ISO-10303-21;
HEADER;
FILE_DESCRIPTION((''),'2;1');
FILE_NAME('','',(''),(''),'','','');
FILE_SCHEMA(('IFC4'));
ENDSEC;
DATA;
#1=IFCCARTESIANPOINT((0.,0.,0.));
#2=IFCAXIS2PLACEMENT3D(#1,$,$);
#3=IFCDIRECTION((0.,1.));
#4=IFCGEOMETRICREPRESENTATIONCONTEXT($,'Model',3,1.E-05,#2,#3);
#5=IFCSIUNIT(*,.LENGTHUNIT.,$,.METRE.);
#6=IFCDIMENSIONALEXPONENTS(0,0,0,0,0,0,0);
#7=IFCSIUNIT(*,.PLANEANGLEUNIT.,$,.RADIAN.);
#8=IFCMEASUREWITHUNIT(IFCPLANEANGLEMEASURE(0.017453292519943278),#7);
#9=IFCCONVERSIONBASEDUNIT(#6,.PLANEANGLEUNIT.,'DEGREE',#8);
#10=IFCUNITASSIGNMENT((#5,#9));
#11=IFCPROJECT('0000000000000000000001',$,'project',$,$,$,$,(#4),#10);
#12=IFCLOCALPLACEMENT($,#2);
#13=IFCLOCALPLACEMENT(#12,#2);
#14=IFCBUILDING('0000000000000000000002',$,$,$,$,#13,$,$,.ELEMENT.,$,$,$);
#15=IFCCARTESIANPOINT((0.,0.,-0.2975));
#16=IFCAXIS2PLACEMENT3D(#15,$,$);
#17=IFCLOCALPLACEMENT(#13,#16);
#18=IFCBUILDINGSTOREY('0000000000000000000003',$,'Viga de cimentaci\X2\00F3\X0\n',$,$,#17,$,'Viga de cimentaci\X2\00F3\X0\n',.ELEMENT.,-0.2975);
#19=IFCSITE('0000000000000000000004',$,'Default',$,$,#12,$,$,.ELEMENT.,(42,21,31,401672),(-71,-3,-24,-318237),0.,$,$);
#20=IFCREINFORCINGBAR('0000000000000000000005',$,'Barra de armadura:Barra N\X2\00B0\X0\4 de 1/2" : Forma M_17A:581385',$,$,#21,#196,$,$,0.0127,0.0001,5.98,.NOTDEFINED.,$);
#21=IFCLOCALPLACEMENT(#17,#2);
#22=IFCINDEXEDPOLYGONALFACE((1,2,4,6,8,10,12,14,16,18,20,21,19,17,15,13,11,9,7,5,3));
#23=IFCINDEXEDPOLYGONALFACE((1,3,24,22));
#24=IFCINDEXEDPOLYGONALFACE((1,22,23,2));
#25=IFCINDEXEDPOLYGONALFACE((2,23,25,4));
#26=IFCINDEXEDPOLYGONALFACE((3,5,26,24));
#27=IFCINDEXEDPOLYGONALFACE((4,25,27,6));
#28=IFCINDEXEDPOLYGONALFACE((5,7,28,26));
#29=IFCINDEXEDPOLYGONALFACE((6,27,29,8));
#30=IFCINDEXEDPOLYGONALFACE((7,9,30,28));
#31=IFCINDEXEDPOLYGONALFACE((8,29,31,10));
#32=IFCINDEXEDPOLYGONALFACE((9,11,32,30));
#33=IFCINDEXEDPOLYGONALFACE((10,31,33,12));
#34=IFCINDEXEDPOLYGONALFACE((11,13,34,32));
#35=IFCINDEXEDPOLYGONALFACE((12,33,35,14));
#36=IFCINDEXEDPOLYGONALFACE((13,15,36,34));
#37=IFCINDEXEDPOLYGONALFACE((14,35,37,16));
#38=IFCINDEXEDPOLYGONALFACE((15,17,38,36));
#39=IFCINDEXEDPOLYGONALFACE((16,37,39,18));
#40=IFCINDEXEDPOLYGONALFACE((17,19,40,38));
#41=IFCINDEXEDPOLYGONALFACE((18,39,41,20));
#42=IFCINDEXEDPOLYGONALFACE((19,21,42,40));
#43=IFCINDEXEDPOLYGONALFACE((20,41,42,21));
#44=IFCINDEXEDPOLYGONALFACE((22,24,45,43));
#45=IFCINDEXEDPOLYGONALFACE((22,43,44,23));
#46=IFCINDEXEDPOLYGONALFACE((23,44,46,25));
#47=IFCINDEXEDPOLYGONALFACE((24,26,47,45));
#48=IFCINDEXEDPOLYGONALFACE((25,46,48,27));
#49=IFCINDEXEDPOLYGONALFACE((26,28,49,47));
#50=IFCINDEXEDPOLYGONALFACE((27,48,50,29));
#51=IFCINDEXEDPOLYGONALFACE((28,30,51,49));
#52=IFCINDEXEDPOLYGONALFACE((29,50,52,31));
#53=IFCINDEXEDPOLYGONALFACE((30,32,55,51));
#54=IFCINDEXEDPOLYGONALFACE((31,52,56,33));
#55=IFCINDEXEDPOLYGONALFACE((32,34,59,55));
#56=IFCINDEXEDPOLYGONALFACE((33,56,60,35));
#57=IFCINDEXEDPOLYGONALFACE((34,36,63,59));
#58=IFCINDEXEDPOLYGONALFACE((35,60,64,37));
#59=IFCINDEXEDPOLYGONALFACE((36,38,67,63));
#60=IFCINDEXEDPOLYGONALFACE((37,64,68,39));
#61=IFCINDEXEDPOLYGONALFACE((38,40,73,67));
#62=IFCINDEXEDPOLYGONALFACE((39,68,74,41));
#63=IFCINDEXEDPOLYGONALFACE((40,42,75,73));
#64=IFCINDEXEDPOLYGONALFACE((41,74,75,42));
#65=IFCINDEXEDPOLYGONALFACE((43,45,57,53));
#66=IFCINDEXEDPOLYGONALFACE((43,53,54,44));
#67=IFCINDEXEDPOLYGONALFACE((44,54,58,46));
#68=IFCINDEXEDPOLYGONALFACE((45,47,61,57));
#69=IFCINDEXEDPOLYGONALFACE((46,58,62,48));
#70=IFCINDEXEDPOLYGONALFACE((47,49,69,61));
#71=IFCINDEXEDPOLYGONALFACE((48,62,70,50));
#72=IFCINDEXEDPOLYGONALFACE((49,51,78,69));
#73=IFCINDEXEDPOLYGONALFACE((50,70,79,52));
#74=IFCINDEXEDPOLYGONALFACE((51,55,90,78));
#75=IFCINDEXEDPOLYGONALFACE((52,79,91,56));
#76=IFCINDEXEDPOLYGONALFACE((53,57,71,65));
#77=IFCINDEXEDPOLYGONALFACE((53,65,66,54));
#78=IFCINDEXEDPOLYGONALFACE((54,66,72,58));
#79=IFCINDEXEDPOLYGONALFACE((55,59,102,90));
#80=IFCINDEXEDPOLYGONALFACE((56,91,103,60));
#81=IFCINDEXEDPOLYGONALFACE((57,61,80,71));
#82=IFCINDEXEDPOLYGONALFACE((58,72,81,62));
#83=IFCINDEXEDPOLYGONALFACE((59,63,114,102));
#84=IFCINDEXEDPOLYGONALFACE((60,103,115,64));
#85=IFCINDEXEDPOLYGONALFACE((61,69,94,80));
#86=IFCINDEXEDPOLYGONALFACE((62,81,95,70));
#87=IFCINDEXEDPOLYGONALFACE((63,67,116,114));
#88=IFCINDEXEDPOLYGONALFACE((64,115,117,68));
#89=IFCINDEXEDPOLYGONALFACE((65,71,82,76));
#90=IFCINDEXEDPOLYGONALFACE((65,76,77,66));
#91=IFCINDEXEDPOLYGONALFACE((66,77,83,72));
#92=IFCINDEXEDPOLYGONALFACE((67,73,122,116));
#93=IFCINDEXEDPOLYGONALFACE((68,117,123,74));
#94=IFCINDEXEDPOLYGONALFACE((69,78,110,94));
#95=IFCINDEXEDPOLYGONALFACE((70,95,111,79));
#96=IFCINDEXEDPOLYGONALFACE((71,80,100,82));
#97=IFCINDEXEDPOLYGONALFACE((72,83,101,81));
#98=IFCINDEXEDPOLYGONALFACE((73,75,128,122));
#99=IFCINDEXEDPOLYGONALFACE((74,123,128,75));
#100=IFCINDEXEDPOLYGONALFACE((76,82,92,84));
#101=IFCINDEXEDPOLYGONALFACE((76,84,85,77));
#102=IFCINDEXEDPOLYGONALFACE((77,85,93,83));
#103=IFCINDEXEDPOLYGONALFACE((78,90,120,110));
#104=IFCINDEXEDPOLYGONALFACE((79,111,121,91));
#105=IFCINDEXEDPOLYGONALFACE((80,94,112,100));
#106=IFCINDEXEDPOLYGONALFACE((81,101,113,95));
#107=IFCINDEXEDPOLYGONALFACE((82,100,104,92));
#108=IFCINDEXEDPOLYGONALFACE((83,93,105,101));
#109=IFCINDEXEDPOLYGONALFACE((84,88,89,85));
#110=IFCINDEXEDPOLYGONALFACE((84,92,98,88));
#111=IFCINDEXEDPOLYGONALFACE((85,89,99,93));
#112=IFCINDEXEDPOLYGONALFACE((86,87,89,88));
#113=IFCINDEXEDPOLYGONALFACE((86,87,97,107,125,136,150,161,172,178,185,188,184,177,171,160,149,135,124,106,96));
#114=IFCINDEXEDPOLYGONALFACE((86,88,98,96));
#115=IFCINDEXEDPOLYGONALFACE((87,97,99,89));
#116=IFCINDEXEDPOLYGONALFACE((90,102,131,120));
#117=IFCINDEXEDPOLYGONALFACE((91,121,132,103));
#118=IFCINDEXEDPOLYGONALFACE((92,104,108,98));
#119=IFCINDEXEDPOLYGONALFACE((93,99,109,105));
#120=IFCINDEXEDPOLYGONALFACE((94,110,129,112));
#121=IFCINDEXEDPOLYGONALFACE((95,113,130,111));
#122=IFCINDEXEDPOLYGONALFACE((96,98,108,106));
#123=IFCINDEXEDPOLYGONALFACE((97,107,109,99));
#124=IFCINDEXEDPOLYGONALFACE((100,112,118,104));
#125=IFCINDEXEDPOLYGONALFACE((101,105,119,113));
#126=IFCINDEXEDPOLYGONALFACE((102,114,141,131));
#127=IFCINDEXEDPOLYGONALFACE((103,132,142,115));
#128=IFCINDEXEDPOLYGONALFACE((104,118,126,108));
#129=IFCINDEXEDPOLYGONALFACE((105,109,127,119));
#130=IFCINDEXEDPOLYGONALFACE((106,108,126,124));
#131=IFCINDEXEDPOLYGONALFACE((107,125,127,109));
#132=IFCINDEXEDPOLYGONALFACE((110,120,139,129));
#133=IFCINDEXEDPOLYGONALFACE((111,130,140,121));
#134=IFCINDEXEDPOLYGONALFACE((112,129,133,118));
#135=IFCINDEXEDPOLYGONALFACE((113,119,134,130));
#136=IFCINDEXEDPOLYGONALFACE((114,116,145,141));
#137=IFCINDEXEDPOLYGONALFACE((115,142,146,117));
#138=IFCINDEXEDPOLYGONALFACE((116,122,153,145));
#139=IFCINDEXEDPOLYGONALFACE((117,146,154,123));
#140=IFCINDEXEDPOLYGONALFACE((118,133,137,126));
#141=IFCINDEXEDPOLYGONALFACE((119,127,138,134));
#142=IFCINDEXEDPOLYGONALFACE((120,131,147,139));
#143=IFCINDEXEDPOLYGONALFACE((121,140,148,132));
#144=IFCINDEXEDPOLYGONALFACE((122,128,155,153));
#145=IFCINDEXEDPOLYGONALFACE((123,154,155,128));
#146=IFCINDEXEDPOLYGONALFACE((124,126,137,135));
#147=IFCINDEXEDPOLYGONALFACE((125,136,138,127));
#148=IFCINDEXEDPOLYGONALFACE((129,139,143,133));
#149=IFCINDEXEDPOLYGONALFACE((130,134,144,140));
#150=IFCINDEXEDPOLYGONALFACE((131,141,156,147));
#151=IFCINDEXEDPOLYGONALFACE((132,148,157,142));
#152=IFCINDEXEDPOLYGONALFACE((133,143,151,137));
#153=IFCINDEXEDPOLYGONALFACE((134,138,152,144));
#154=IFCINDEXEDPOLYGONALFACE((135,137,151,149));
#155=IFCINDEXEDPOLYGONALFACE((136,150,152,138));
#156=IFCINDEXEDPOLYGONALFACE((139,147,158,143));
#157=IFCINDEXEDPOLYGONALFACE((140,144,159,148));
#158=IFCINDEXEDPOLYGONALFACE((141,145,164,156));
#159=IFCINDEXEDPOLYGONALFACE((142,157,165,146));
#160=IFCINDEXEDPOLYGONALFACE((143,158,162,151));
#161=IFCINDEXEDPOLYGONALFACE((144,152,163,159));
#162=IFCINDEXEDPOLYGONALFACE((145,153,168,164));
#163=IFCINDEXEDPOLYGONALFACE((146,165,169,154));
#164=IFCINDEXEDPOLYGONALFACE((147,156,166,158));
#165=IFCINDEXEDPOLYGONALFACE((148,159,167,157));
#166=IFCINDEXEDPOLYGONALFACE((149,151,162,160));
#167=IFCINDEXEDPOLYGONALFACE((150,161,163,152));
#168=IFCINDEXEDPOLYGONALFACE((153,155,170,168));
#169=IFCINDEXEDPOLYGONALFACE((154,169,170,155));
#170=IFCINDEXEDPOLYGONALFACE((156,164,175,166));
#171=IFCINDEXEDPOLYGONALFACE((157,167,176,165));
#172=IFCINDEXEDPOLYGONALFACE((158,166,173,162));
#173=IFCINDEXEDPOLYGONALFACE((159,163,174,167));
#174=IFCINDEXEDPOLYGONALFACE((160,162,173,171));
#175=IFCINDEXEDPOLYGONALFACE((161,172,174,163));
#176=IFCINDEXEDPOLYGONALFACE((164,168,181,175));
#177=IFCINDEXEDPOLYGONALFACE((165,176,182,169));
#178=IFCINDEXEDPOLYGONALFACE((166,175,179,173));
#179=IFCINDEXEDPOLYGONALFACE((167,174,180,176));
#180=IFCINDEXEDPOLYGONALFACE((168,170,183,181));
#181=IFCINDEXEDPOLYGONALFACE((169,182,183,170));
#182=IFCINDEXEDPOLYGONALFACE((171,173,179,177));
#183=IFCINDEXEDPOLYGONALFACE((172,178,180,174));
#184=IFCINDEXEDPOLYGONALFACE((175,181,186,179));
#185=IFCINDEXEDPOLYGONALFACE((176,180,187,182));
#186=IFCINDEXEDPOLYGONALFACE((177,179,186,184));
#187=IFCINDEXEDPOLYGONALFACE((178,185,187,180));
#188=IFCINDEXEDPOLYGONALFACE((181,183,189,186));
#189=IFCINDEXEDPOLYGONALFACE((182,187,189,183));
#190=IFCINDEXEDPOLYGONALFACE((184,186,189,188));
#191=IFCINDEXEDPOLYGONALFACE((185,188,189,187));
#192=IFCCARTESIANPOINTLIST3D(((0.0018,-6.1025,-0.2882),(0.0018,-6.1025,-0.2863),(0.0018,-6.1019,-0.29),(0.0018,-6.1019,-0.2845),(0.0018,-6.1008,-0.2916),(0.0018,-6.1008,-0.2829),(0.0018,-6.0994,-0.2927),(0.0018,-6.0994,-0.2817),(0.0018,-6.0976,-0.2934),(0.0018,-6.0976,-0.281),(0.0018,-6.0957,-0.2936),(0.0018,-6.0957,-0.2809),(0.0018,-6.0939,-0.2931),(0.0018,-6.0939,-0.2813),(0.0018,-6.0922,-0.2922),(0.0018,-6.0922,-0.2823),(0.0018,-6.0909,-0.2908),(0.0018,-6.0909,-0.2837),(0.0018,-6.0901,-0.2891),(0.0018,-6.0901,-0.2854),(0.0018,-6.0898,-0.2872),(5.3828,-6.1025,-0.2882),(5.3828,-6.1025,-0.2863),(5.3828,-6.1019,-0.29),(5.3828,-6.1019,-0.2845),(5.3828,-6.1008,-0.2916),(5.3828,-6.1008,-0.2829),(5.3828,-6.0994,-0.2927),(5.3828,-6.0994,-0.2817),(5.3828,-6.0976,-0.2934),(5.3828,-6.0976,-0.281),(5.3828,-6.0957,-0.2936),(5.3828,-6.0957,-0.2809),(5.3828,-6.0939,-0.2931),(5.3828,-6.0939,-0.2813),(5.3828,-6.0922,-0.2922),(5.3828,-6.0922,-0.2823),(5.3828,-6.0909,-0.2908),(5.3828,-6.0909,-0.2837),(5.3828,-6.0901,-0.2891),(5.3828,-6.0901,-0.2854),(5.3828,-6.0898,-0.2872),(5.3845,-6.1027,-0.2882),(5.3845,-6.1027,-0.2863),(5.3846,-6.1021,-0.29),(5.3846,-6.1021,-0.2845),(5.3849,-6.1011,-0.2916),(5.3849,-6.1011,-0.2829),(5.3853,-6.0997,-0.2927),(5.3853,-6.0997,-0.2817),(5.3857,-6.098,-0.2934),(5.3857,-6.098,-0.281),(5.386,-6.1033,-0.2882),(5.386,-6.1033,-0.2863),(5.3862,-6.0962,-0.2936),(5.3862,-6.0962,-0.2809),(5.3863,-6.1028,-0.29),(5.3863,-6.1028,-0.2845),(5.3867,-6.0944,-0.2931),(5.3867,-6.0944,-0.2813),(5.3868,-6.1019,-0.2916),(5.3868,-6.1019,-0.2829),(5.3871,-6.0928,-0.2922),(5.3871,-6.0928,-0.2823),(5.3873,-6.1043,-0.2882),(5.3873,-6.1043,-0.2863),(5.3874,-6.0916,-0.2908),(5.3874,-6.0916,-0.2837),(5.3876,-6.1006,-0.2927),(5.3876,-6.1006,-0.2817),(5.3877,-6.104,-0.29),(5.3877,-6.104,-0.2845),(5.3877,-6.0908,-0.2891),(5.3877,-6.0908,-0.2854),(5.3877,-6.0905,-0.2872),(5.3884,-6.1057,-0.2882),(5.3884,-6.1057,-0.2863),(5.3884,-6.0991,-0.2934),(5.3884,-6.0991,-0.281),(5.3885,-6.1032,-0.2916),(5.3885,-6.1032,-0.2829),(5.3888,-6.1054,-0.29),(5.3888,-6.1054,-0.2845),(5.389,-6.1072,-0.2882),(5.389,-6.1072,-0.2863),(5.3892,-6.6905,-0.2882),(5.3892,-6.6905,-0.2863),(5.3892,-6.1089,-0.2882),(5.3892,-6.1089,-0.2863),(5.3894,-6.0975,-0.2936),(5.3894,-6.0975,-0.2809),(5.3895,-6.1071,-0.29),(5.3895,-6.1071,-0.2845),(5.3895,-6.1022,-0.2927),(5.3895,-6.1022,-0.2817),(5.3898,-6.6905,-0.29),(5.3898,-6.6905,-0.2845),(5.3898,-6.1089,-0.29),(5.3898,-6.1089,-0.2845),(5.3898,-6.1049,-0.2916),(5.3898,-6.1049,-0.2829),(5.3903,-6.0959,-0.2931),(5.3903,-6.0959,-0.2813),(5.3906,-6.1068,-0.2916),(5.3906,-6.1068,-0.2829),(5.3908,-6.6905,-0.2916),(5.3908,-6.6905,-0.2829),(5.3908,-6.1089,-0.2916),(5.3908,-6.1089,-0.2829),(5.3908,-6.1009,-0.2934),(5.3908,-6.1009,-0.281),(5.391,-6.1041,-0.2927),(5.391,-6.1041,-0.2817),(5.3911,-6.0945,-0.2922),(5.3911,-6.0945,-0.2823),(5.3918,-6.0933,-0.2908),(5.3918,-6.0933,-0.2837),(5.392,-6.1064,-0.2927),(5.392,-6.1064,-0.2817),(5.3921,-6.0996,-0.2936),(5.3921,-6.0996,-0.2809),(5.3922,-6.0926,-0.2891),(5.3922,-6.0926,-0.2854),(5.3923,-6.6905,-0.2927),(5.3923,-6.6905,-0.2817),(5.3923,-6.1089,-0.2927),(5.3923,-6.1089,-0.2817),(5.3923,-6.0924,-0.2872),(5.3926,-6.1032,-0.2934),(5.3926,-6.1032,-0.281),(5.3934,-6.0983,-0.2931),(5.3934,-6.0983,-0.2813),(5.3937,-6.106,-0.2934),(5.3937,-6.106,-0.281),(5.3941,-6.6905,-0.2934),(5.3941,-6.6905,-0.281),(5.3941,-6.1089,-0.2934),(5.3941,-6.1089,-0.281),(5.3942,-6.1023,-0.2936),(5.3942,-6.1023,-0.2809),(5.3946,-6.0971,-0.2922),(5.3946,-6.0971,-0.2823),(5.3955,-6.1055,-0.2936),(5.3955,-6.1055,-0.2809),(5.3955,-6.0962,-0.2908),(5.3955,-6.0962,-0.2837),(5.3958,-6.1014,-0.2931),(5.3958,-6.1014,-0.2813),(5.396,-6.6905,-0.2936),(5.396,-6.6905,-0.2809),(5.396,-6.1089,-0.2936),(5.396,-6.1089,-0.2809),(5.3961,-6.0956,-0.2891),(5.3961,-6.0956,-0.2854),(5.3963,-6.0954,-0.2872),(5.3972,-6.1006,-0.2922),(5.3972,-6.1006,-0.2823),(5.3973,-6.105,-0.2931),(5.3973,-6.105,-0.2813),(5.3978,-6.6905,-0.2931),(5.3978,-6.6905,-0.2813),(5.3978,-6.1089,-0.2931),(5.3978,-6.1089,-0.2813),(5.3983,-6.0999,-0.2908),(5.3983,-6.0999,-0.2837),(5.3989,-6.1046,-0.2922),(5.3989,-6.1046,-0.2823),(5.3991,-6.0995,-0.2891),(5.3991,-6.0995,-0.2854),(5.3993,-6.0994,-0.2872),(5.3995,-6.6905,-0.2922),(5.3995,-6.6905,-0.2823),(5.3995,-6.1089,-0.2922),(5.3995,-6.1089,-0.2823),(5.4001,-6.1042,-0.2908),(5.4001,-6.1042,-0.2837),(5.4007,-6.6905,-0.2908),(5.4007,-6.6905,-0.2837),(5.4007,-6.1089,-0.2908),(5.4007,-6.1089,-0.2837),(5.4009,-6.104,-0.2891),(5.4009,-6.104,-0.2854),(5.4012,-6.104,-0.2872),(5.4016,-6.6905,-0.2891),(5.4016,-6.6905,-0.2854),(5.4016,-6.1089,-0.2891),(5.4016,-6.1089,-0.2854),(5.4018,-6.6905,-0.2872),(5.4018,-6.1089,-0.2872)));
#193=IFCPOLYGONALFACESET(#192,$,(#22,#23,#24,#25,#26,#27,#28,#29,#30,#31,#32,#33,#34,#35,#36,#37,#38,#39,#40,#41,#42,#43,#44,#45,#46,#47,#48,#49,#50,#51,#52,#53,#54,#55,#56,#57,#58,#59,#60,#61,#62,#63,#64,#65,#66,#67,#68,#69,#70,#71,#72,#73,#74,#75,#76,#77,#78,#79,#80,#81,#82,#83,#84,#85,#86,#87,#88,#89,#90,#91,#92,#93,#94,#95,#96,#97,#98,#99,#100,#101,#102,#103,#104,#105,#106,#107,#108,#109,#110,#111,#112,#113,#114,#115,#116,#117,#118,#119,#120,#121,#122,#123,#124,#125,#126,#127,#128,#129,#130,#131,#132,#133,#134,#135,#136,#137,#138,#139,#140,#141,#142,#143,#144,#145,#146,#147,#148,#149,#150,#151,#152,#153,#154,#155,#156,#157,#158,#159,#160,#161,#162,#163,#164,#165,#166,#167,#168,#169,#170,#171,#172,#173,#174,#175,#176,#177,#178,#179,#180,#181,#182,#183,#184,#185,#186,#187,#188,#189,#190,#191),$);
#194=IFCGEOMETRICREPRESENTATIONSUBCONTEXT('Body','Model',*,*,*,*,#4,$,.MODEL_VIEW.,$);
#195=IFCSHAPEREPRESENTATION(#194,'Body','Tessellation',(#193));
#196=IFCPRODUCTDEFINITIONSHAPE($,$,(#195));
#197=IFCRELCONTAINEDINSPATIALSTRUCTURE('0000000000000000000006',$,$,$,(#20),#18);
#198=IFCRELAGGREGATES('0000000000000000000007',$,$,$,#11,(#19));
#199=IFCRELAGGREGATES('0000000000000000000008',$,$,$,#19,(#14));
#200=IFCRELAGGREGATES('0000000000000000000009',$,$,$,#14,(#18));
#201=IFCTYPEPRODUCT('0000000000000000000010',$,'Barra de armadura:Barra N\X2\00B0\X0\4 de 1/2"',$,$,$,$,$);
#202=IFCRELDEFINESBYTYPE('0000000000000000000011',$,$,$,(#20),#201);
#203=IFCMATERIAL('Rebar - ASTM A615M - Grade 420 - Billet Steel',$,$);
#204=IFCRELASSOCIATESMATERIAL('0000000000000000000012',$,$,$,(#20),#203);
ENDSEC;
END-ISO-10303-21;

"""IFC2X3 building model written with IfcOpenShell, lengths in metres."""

from ifc_helpers import new_model, entity, si_unit, converted_unit, direction, frame, origin, place, context, subcontext, project, spatial, material, type_object, element, save


model = new_model("IFC2X3")

# Units and contexts
model_context = context("Model", 3, precision=1e-05, world=origin(), true_north=direction((0.0, 1.0)))
body_context = subcontext(model_context, "Body", "Model", "MODEL_VIEW")
ifc_project = project(units=[si_unit("LENGTHUNIT", "METRE"), converted_unit("PLANEANGLEUNIT", "DEGREE", entity("IfcPlaneAngleMeasure", 0.017453292519943278), si_unit("PLANEANGLEUNIT", "RADIAN"), dimensions=[0, 0, 0, 0, 0, 0, 0])], contexts=[model_context])

# Site, building, storey
site_placement = place(None, origin())
site = spatial("IfcSite", under=ifc_project, at=site_placement, Name="Default", CompositionType="ELEMENT", RefLatitude=(42, 21, 31, 401672), RefLongitude=(-71, -3, -24, -318237), RefElevation=0.0)
building_placement = place(site_placement, origin())
building = spatial("IfcBuilding", under=site, at=building_placement, CompositionType="ELEMENT")
storey_placement = place(building_placement, frame((0.0, 0.0, -0.2975)))
storey = spatial("IfcBuildingStorey", under=building, at=storey_placement, Name="Viga de cimentación", LongName="Viga de cimentación", CompositionType="ELEMENT", Elevation=-0.2975)

# Reinforcing bar
ifc_material = material(Name="Rebar - ASTM A615M - Grade 420 - Billet Steel")
type_product_1 = type_object("IfcTypeProduct", Name="Barra de armadura:Barra N°4 de 1/2\"")
reinforcing_bar_1_placement = place(storey_placement, origin())
element("IfcReinforcingBar", 1, at=reinforcing_bar_1_placement, inside=storey, type_object=type_product_1, material=ifc_material, Name="Barra de armadura:Barra N°4 de 1/2\" : Forma M_17A:581385", BarLength=5.98, BarRole="NOTDEFINED", CrossSectionArea=0.0001, NominalDiameter=0.0127, context=body_context, shape_type="AdvancedSweptSolid", body=[
    entity("IfcSweptDiskSolid", entity("IfcCompositeCurve", [entity("IfcCompositeCurveSegment", "CONTINUOUS", True, entity("IfcPolyline", [entity("IfcCartesianPoint", [5.3955, -6.6905, -0.2872]), entity("IfcCartesianPoint", [5.3955, -6.1089, -0.2872])])), entity("IfcCompositeCurveSegment", "CONTINUOUS", True, entity("IfcTrimmedCurve", entity("IfcCircle", entity("IfcAxis2Placement3D", entity("IfcCartesianPoint", [5.3828, -6.1089, -0.2872]), entity("IfcDirection", [0.0, 0.0, 1.0]), entity("IfcDirection", [0.0, 1.0, 0.0])), 0.0127), [entity("IfcParameterValue", 270.0)], [entity("IfcParameterValue", 360.0)], True, "PARAMETER")), entity("IfcCompositeCurveSegment", "CONTINUOUS", True, entity("IfcPolyline", [entity("IfcCartesianPoint", [5.3828, -6.0962, -0.2872]), entity("IfcCartesianPoint", [0.0018, -6.0962, -0.2872])]))], False), 0.0063, None, 0.0, 92.0),
])

save(model, "model.ifc")
